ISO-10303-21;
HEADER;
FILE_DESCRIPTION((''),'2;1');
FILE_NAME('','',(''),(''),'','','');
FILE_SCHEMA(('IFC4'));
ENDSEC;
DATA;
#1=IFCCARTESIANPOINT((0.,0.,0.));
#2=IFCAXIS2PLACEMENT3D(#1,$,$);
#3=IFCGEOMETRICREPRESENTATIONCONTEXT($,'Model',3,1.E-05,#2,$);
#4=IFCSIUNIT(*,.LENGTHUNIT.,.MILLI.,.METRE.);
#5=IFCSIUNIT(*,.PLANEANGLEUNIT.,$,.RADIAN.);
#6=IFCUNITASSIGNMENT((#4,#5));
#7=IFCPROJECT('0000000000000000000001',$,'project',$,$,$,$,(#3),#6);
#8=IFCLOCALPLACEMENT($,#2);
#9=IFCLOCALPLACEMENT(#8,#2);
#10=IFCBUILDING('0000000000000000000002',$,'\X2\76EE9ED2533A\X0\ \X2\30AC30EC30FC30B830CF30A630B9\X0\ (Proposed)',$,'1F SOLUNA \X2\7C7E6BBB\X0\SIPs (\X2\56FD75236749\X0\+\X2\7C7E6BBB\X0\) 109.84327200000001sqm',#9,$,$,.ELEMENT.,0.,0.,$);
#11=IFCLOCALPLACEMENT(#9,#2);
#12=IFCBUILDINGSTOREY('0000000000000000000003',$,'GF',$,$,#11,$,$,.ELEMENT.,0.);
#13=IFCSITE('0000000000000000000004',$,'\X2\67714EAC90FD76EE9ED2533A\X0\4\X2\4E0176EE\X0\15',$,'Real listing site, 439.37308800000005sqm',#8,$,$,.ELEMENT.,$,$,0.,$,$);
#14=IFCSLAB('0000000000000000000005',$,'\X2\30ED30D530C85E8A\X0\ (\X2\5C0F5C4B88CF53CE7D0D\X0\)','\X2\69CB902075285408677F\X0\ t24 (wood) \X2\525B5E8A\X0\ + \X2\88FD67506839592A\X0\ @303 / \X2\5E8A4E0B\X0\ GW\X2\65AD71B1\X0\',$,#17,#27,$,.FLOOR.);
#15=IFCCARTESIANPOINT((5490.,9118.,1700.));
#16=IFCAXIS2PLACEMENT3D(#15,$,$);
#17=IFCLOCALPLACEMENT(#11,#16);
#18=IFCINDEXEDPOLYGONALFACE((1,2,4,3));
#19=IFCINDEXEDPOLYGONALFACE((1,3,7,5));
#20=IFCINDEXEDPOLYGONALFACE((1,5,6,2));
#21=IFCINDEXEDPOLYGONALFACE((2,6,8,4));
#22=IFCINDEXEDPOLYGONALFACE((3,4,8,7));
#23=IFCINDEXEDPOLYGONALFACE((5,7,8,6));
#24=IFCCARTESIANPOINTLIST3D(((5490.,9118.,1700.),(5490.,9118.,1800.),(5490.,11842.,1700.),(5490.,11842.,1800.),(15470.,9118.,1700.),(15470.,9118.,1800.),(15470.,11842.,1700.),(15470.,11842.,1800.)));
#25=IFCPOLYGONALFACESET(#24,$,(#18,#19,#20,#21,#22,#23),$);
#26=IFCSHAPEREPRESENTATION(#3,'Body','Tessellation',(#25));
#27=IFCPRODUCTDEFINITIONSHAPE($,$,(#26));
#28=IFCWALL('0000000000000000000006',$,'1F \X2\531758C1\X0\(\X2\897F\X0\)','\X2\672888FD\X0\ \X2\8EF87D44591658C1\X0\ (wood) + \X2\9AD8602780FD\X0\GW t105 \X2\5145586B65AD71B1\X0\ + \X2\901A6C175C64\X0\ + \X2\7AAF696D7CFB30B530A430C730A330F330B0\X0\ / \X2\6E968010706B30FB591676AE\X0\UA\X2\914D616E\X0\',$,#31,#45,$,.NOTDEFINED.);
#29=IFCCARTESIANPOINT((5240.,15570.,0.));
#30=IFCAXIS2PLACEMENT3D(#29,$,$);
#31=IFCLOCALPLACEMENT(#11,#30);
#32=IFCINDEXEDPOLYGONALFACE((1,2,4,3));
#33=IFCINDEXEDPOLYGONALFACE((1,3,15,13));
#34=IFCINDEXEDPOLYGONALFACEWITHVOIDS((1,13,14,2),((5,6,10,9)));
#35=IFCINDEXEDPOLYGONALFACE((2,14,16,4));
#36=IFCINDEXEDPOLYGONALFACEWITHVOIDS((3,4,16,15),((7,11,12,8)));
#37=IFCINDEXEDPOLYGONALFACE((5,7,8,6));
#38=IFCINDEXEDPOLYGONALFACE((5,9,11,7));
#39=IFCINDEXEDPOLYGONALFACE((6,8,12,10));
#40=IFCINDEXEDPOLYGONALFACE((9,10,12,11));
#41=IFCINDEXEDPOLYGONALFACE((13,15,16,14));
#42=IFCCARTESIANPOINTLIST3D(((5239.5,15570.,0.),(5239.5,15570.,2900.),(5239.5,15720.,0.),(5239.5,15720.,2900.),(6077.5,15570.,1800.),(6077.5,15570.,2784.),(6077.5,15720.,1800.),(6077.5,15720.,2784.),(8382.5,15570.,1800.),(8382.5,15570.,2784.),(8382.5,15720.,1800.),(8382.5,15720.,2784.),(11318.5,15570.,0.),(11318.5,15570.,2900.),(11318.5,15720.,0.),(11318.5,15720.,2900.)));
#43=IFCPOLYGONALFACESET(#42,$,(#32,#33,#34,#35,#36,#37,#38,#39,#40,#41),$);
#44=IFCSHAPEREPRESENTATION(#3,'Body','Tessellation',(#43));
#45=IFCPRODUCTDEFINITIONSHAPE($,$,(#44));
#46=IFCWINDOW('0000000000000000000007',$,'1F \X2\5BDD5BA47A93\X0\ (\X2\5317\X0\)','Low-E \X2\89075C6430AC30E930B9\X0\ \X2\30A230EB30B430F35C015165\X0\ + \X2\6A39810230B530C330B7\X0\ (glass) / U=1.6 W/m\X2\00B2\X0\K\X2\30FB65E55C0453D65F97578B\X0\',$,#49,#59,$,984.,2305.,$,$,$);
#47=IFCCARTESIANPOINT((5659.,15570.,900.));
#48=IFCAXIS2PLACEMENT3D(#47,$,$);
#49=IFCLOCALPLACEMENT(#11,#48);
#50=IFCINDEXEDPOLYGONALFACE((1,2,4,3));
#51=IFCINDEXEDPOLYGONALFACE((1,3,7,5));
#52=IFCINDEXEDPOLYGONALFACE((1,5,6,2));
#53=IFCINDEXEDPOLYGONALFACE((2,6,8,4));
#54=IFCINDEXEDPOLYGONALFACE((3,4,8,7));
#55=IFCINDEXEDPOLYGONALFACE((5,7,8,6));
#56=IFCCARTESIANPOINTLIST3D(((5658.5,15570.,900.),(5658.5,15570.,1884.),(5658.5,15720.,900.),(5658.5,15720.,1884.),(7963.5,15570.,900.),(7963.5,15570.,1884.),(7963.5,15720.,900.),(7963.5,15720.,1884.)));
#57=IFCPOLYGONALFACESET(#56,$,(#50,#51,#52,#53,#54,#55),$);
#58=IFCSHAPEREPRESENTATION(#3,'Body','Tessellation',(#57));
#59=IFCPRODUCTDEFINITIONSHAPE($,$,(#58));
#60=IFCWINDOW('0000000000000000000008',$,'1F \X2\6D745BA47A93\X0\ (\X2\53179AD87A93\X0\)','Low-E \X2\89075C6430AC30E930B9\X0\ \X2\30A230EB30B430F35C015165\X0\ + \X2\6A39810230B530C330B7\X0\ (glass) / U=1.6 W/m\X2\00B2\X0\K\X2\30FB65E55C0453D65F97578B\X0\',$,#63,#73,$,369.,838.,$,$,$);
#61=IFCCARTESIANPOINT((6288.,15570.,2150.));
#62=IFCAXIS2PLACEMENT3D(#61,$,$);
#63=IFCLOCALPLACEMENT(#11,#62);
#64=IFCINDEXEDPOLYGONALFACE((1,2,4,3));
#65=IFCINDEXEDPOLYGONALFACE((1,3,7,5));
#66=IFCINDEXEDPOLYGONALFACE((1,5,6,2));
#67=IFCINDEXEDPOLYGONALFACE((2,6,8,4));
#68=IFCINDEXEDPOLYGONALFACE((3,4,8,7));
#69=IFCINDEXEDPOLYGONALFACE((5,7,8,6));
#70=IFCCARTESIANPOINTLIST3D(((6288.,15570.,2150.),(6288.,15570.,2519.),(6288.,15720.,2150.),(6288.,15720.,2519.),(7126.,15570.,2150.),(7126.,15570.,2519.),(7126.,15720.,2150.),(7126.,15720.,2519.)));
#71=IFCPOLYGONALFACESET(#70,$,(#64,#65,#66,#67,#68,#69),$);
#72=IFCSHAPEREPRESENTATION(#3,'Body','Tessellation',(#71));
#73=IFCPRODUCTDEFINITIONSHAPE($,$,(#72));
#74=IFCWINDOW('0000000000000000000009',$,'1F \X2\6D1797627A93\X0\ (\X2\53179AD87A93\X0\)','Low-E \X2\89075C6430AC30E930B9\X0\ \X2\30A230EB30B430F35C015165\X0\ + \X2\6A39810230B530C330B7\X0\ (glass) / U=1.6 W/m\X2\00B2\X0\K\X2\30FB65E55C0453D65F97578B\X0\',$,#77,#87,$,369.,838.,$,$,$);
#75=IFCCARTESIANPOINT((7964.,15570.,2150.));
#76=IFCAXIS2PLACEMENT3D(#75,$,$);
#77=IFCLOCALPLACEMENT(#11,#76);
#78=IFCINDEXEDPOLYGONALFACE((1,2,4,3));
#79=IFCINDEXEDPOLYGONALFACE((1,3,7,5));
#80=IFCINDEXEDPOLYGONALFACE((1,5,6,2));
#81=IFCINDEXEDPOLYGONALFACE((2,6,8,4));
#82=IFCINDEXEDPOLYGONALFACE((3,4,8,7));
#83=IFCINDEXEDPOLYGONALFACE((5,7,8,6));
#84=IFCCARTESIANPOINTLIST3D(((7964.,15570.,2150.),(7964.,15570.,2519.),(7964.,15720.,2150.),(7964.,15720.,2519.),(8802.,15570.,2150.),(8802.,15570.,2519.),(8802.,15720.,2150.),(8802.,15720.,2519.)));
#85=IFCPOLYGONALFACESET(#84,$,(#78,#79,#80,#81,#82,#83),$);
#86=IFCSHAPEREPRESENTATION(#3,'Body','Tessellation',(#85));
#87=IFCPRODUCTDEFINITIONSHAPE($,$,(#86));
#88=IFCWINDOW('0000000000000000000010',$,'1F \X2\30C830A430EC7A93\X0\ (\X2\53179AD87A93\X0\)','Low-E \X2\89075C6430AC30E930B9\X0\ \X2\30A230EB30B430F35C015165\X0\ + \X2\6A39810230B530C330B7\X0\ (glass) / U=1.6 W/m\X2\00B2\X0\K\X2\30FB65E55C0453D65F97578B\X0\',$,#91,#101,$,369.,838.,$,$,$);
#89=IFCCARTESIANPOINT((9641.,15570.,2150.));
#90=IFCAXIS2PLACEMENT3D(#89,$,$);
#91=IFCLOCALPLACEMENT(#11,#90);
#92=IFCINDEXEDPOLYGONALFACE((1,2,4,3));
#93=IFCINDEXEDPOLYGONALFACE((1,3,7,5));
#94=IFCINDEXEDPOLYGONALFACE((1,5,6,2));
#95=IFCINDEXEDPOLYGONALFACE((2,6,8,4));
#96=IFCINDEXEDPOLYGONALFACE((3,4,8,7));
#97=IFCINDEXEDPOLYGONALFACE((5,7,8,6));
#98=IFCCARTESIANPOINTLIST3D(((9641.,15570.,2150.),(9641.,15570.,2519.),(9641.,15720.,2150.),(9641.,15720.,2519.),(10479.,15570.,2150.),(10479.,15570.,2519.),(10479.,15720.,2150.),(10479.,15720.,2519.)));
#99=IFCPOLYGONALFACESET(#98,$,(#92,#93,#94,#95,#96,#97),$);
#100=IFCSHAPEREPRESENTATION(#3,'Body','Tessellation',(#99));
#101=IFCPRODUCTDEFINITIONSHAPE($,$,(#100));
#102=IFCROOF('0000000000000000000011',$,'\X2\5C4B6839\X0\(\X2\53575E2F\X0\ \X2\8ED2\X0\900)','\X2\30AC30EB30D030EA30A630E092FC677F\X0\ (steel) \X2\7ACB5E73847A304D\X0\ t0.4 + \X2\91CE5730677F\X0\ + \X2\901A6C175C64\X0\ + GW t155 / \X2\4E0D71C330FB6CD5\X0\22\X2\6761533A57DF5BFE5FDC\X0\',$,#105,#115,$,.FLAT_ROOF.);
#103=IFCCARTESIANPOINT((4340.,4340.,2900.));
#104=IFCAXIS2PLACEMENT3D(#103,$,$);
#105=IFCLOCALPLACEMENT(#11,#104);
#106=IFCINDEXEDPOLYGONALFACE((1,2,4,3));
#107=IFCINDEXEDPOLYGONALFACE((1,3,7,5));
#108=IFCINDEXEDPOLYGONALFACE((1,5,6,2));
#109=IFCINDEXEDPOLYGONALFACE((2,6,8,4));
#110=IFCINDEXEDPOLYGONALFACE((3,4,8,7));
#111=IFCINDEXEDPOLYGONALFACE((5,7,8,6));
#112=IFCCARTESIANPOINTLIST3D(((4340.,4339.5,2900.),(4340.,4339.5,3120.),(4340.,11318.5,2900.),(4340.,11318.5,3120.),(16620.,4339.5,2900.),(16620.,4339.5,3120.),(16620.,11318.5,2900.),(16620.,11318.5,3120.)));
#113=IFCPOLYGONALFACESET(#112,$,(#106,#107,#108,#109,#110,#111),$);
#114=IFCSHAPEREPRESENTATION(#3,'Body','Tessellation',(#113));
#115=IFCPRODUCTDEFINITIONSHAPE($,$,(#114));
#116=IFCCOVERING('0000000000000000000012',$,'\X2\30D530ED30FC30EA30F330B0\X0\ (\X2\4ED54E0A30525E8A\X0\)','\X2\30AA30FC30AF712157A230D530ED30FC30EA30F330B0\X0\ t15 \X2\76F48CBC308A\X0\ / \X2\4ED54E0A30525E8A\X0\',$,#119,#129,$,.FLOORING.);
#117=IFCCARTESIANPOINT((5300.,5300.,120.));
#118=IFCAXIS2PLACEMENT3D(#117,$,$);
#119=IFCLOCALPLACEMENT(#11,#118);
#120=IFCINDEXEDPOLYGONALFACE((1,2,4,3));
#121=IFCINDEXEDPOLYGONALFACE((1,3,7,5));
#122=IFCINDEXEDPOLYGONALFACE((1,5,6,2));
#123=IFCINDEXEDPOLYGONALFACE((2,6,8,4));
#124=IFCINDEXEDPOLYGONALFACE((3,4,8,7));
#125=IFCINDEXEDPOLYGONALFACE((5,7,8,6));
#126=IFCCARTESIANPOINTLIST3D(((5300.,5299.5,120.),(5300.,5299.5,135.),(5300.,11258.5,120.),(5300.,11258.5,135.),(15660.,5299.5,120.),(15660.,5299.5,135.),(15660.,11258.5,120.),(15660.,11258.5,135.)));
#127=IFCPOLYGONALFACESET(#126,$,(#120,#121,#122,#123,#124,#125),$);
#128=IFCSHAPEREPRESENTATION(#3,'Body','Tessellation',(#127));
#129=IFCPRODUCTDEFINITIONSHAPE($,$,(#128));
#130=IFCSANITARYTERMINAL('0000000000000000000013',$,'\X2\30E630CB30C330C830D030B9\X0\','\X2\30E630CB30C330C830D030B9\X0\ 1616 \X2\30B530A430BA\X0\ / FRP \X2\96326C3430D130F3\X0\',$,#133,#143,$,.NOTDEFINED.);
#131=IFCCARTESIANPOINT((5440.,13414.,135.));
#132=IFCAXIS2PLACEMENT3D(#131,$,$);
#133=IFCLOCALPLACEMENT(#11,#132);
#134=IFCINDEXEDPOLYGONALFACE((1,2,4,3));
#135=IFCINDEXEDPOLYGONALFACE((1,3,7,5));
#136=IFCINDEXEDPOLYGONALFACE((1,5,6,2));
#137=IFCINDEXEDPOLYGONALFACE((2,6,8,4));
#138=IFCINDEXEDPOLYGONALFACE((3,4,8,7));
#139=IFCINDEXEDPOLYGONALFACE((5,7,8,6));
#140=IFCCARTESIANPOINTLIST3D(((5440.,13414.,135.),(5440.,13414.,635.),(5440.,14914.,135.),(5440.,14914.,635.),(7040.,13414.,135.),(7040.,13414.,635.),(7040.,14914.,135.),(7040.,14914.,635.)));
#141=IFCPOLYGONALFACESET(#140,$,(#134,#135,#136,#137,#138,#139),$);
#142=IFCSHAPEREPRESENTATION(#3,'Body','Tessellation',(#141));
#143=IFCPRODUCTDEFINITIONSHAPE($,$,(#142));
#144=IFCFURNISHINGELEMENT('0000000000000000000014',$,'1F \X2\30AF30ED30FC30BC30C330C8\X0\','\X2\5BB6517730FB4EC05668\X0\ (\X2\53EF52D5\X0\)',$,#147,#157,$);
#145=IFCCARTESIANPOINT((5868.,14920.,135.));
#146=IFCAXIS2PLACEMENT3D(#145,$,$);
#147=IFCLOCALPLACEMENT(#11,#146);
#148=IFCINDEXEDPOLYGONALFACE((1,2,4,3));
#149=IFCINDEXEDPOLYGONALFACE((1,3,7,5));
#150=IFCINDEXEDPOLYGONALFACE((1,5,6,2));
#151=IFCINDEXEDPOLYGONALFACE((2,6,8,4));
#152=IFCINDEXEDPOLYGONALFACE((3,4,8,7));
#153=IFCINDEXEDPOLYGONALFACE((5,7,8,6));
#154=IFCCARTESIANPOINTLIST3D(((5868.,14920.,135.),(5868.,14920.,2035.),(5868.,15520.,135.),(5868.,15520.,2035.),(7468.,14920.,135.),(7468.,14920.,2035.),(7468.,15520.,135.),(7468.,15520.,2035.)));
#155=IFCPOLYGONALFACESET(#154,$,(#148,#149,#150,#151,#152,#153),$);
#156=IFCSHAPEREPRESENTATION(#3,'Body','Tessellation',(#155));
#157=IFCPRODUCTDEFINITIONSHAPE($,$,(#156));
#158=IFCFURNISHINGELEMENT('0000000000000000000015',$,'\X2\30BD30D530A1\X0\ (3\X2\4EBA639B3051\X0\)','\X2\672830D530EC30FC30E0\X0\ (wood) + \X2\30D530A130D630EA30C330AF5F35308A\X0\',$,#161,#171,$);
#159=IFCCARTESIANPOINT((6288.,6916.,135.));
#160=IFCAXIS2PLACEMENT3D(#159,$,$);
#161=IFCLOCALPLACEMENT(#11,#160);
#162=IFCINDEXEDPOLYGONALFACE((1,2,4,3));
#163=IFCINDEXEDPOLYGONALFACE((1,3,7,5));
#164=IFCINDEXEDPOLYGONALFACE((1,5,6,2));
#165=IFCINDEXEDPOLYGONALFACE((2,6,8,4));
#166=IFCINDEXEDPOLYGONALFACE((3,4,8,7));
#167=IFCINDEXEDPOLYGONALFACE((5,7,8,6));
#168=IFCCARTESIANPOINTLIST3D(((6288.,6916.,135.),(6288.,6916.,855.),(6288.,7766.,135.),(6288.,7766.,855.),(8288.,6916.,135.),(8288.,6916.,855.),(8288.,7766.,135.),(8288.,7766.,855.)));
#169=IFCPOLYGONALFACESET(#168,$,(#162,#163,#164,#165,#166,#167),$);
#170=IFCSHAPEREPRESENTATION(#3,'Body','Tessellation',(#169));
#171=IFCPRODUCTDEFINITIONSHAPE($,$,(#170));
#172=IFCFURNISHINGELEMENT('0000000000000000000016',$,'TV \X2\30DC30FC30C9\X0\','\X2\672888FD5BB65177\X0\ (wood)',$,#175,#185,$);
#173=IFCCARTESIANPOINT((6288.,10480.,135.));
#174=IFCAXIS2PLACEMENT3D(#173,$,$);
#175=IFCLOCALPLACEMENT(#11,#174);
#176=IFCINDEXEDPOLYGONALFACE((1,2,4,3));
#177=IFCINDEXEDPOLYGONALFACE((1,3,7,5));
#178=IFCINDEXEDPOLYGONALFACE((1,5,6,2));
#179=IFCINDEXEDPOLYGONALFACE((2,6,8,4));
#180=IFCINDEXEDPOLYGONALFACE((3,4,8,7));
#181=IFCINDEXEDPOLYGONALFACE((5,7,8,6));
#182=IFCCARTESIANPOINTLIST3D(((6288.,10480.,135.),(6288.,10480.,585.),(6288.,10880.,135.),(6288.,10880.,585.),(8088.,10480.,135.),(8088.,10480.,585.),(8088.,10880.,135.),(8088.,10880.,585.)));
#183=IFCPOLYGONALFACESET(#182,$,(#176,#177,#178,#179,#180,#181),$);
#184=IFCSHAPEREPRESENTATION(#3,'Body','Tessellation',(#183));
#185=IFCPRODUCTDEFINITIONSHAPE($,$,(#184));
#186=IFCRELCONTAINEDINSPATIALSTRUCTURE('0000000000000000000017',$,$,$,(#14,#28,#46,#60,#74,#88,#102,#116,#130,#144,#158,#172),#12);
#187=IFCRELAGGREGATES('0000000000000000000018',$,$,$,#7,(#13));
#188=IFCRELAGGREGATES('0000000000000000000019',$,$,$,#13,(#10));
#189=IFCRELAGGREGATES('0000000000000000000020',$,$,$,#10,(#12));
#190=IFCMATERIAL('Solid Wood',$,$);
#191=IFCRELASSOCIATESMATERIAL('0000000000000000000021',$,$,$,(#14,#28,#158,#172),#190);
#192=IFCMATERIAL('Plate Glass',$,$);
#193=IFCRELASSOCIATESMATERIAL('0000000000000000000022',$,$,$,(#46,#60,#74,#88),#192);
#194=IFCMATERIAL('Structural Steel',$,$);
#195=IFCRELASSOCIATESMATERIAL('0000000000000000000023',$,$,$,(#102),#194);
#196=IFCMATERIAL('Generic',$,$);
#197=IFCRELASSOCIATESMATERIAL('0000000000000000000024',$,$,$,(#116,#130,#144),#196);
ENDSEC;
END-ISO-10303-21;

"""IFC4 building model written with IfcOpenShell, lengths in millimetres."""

from ifc_helpers import new_model, si_unit, frame, frame_2d, origin, place, context, project, spatial, rectangle, extrude, material, element, fill, save


model = new_model("IFC4")

# Units and contexts
model_context = context("Model", 3, precision=1e-05, world=origin())
ifc_project = project(units=[si_unit("LENGTHUNIT", "METRE", prefix="MILLI"), si_unit("PLANEANGLEUNIT", "RADIAN")], contexts=[model_context])

# Site, building, storey
site_placement = place(None, origin())
site = spatial("IfcSite", under=ifc_project, at=site_placement, Name="東京都目黒区4丁目15", ObjectType="Real listing site, 439.37308800000005sqm", CompositionType="ELEMENT", RefElevation=0.0)
building_placement = place(site_placement, origin())
building = spatial("IfcBuilding", under=site, at=building_placement, Name="目黒区 ガレージハウス (Proposed)", ObjectType="1F SOLUNA 籾殻SIPs (国産杉+籾殻) 109.84327200000001sqm", CompositionType="ELEMENT", ElevationOfRefHeight=0.0, ElevationOfTerrain=0.0)
storey_placement = place(building_placement, origin())
storey = spatial("IfcBuildingStorey", under=building, at=storey_placement, Name="GF", CompositionType="ELEMENT", Elevation=0.0)

# Slab
ifc_material_1 = material(Name="Solid Wood")
slab_1_placement = place(storey_placement, frame((5490.0, 9118.0, 1700.0)))
element("IfcSlab", 1, at=slab_1_placement, inside=storey, material=ifc_material_1, Name="ロフト床 (小屋裏収納)", Description="構造用合板 t24 (wood) 剛床 + 製材根太 @303 / 床下 GW断熱", PredefinedType="FLOOR", context=model_context, shape_type="SweptSolid", body=[
    extrude(rectangle(XDim=9980.0, YDim=2724.0, at=frame_2d((4990.0, 1362.0))), frame((5490.0, 9118.0, 1700.0)), (0.0, 0.0, 1.0), 100.0),
])

# Shared definitions
ifc_material_2 = material(Name="Plate Glass")

# Wall, openings, windows
wall_1_placement = place(storey_placement, frame((5240.0, 15570.0, 0.0)))
wall_1 = element("IfcWall", 2, at=wall_1_placement, inside=storey, material=ifc_material_1, Name="1F 北壁(西)", Description="木製 軸組外壁 (wood) + 高性能GW t105 充填断熱 + 通気層 + 窯業系サイディング / 準耐火・外皮UA配慮", PredefinedType="NOTDEFINED", context=model_context, shape_type="SweptSolid", body=[
    extrude(rectangle(XDim=6079.0, YDim=150.0, at=frame_2d((3039.0, 75.0))), frame((5240.0, 15570.0, 0.0)), (0.0, 0.0, 1.0), 2900.0),
])
opening_1_placement = place(storey_placement, frame((5659.0, 15570.0, 900.0)))
opening_1 = element("IfcOpeningElement", 3, at=opening_1_placement, cuts=wall_1, PredefinedType="NOTDEFINED", context=model_context, shape_type="SweptSolid", body=[
    extrude(rectangle(XDim=2305.0, YDim=150.0, at=frame_2d((1152.0, 75.0))), frame((5659.0, 15570.0, 900.0)), (0.0, 0.0, 1.0), 984.0),
])
opening_2_placement = place(storey_placement, frame((6288.0, 15570.0, 2150.0)))
opening_2 = element("IfcOpeningElement", 4, at=opening_2_placement, cuts=wall_1, PredefinedType="NOTDEFINED", context=model_context, shape_type="SweptSolid", body=[
    extrude(rectangle(XDim=838.0, YDim=150.0, at=frame_2d((419.0, 75.0))), frame((6288.0, 15570.0, 2150.0)), (0.0, 0.0, 1.0), 369.0),
])
opening_3_placement = place(storey_placement, frame((7964.0, 15570.0, 2150.0)))
opening_3 = element("IfcOpeningElement", 5, at=opening_3_placement, cuts=wall_1, PredefinedType="NOTDEFINED", context=model_context, shape_type="SweptSolid", body=[
    extrude(rectangle(XDim=838.0, YDim=150.0, at=frame_2d((419.0, 75.0))), frame((7964.0, 15570.0, 2150.0)), (0.0, 0.0, 1.0), 369.0),
])
opening_4_placement = place(storey_placement, frame((9641.0, 15570.0, 2150.0)))
opening_4 = element("IfcOpeningElement", 6, at=opening_4_placement, cuts=wall_1, PredefinedType="NOTDEFINED", context=model_context, shape_type="SweptSolid", body=[
    extrude(rectangle(XDim=838.0, YDim=150.0, at=frame_2d((419.0, 75.0))), frame((9641.0, 15570.0, 2150.0)), (0.0, 0.0, 1.0), 369.0),
])
window_1_placement = place(storey_placement, frame((5659.0, 15570.0, 900.0)))
window_1 = element("IfcWindow", 7, at=window_1_placement, inside=storey, material=ifc_material_2, Name="1F 寝室窓 (北)", Description="Low-E 複層ガラス アルゴン封入 + 樹脂サッシ (glass) / U=1.6 W/m²K・日射取得型", OverallHeight=984.0, OverallWidth=2305.0, context=model_context, shape_type="SweptSolid", body=[
    extrude(rectangle(XDim=2305.0, YDim=150.0, at=frame_2d((1152.0, 75.0))), frame((5659.0, 15570.0, 900.0)), (0.0, 0.0, 1.0), 984.0),
])
fill(opening_1, window_1)
window_2_placement = place(storey_placement, frame((6288.0, 15570.0, 2150.0)))
window_2 = element("IfcWindow", 8, at=window_2_placement, inside=storey, material=ifc_material_2, Name="1F 浴室窓 (北高窓)", Description="Low-E 複層ガラス アルゴン封入 + 樹脂サッシ (glass) / U=1.6 W/m²K・日射取得型", OverallHeight=369.0, OverallWidth=838.0, context=model_context, shape_type="SweptSolid", body=[
    extrude(rectangle(XDim=838.0, YDim=150.0, at=frame_2d((419.0, 75.0))), frame((6288.0, 15570.0, 2150.0)), (0.0, 0.0, 1.0), 369.0),
])
fill(opening_2, window_2)
window_3_placement = place(storey_placement, frame((7964.0, 15570.0, 2150.0)))
window_3 = element("IfcWindow", 9, at=window_3_placement, inside=storey, material=ifc_material_2, Name="1F 洗面窓 (北高窓)", Description="Low-E 複層ガラス アルゴン封入 + 樹脂サッシ (glass) / U=1.6 W/m²K・日射取得型", OverallHeight=369.0, OverallWidth=838.0, context=model_context, shape_type="SweptSolid", body=[
    extrude(rectangle(XDim=838.0, YDim=150.0, at=frame_2d((419.0, 75.0))), frame((7964.0, 15570.0, 2150.0)), (0.0, 0.0, 1.0), 369.0),
])
fill(opening_3, window_3)
window_4_placement = place(storey_placement, frame((9641.0, 15570.0, 2150.0)))
window_4 = element("IfcWindow", 10, at=window_4_placement, inside=storey, material=ifc_material_2, Name="1F トイレ窓 (北高窓)", Description="Low-E 複層ガラス アルゴン封入 + 樹脂サッシ (glass) / U=1.6 W/m²K・日射取得型", OverallHeight=369.0, OverallWidth=838.0, context=model_context, shape_type="SweptSolid", body=[
    extrude(rectangle(XDim=838.0, YDim=150.0, at=frame_2d((419.0, 75.0))), frame((9641.0, 15570.0, 2150.0)), (0.0, 0.0, 1.0), 369.0),
])
fill(opening_4, window_4)

# Roof
ifc_material_3 = material(Name="Structural Steel")
roof_1_placement = place(storey_placement, frame((4340.0, 4340.0, 2900.0)))
element("IfcRoof", 11, at=roof_1_placement, inside=storey, material=ifc_material_3, Name="屋根(南帯 軒900)", Description="ガルバリウム鋼板 (steel) 立平葺き t0.4 + 野地板 + 通気層 + GW t155 / 不燃・法22条区域対応", PredefinedType="FLAT_ROOF", context=model_context, shape_type="SweptSolid", body=[
    extrude(rectangle(XDim=12280.0, YDim=6979.0, at=frame_2d((6140.0, 3489.0))), frame((4340.0, 4340.0, 2900.0)), (0.0, 0.0, 1.0), 220.0),
])

# Covering
ifc_material_4 = material(Name="Generic")
covering_1_placement = place(storey_placement, frame((5300.0, 5300.0, 120.0)))
element("IfcCovering", 12, at=covering_1_placement, inside=storey, material=ifc_material_4, Name="フローリング (仕上げ床)", Description="オーク無垢フローリング t15 直貼り / 仕上げ床", PredefinedType="FLOORING", context=model_context, shape_type="SweptSolid", body=[
    extrude(rectangle(XDim=10360.0, YDim=5959.0, at=frame_2d((5180.0, 2979.0))), frame((5300.0, 5300.0, 120.0)), (0.0, 0.0, 1.0), 15.0),
])

# Sanitary terminal
sanitary_terminal_placement = place(storey_placement, frame((5440.0, 13414.0, 135.0)))
element("IfcSanitaryTerminal", 13, at=sanitary_terminal_placement, inside=storey, material=ifc_material_4, Name="ユニットバス", Description="ユニットバス 1616 サイズ / FRP 防水パン", PredefinedType="NOTDEFINED", context=model_context, shape_type="SweptSolid", body=[
    extrude(rectangle(XDim=1600.0, YDim=1500.0, at=frame_2d((800.0, 750.0))), frame((5440.0, 13414.0, 135.0)), (0.0, 0.0, 1.0), 500.0),
])

# Furnishing elements
furnishing_1_placement = place(storey_placement, frame((5868.0, 14920.0, 135.0)))
element("IfcFurnishingElement", 14, at=furnishing_1_placement, inside=storey, material=ifc_material_4, Name="1F クローゼット", Description="家具・什器 (可動)", context=model_context, shape_type="SweptSolid", body=[
    extrude(rectangle(XDim=1600.0, YDim=600.0, at=frame_2d((800.0, 300.0))), frame((5868.0, 14920.0, 135.0)), (0.0, 0.0, 1.0), 1900.0),
])
furnishing_2_placement = place(storey_placement, frame((6288.0, 6916.0, 135.0)))
element("IfcFurnishingElement", 15, at=furnishing_2_placement, inside=storey, material=ifc_material_1, Name="ソファ (3人掛け)", Description="木フレーム (wood) + ファブリック張り", context=model_context, shape_type="SweptSolid", body=[
    extrude(rectangle(XDim=2000.0, YDim=850.0, at=frame_2d((1000.0, 425.0))), frame((6288.0, 6916.0, 135.0)), (0.0, 0.0, 1.0), 720.0),
])
furnishing_3_placement = place(storey_placement, frame((6288.0, 10480.0, 135.0)))
element("IfcFurnishingElement", 16, at=furnishing_3_placement, inside=storey, material=ifc_material_1, Name="TV ボード", Description="木製家具 (wood)", context=model_context, shape_type="SweptSolid", body=[
    extrude(rectangle(XDim=1800.0, YDim=400.0, at=frame_2d((900.0, 200.0))), frame((6288.0, 10480.0, 135.0)), (0.0, 0.0, 1.0), 450.0),
])

save(model, "model.ifc")
